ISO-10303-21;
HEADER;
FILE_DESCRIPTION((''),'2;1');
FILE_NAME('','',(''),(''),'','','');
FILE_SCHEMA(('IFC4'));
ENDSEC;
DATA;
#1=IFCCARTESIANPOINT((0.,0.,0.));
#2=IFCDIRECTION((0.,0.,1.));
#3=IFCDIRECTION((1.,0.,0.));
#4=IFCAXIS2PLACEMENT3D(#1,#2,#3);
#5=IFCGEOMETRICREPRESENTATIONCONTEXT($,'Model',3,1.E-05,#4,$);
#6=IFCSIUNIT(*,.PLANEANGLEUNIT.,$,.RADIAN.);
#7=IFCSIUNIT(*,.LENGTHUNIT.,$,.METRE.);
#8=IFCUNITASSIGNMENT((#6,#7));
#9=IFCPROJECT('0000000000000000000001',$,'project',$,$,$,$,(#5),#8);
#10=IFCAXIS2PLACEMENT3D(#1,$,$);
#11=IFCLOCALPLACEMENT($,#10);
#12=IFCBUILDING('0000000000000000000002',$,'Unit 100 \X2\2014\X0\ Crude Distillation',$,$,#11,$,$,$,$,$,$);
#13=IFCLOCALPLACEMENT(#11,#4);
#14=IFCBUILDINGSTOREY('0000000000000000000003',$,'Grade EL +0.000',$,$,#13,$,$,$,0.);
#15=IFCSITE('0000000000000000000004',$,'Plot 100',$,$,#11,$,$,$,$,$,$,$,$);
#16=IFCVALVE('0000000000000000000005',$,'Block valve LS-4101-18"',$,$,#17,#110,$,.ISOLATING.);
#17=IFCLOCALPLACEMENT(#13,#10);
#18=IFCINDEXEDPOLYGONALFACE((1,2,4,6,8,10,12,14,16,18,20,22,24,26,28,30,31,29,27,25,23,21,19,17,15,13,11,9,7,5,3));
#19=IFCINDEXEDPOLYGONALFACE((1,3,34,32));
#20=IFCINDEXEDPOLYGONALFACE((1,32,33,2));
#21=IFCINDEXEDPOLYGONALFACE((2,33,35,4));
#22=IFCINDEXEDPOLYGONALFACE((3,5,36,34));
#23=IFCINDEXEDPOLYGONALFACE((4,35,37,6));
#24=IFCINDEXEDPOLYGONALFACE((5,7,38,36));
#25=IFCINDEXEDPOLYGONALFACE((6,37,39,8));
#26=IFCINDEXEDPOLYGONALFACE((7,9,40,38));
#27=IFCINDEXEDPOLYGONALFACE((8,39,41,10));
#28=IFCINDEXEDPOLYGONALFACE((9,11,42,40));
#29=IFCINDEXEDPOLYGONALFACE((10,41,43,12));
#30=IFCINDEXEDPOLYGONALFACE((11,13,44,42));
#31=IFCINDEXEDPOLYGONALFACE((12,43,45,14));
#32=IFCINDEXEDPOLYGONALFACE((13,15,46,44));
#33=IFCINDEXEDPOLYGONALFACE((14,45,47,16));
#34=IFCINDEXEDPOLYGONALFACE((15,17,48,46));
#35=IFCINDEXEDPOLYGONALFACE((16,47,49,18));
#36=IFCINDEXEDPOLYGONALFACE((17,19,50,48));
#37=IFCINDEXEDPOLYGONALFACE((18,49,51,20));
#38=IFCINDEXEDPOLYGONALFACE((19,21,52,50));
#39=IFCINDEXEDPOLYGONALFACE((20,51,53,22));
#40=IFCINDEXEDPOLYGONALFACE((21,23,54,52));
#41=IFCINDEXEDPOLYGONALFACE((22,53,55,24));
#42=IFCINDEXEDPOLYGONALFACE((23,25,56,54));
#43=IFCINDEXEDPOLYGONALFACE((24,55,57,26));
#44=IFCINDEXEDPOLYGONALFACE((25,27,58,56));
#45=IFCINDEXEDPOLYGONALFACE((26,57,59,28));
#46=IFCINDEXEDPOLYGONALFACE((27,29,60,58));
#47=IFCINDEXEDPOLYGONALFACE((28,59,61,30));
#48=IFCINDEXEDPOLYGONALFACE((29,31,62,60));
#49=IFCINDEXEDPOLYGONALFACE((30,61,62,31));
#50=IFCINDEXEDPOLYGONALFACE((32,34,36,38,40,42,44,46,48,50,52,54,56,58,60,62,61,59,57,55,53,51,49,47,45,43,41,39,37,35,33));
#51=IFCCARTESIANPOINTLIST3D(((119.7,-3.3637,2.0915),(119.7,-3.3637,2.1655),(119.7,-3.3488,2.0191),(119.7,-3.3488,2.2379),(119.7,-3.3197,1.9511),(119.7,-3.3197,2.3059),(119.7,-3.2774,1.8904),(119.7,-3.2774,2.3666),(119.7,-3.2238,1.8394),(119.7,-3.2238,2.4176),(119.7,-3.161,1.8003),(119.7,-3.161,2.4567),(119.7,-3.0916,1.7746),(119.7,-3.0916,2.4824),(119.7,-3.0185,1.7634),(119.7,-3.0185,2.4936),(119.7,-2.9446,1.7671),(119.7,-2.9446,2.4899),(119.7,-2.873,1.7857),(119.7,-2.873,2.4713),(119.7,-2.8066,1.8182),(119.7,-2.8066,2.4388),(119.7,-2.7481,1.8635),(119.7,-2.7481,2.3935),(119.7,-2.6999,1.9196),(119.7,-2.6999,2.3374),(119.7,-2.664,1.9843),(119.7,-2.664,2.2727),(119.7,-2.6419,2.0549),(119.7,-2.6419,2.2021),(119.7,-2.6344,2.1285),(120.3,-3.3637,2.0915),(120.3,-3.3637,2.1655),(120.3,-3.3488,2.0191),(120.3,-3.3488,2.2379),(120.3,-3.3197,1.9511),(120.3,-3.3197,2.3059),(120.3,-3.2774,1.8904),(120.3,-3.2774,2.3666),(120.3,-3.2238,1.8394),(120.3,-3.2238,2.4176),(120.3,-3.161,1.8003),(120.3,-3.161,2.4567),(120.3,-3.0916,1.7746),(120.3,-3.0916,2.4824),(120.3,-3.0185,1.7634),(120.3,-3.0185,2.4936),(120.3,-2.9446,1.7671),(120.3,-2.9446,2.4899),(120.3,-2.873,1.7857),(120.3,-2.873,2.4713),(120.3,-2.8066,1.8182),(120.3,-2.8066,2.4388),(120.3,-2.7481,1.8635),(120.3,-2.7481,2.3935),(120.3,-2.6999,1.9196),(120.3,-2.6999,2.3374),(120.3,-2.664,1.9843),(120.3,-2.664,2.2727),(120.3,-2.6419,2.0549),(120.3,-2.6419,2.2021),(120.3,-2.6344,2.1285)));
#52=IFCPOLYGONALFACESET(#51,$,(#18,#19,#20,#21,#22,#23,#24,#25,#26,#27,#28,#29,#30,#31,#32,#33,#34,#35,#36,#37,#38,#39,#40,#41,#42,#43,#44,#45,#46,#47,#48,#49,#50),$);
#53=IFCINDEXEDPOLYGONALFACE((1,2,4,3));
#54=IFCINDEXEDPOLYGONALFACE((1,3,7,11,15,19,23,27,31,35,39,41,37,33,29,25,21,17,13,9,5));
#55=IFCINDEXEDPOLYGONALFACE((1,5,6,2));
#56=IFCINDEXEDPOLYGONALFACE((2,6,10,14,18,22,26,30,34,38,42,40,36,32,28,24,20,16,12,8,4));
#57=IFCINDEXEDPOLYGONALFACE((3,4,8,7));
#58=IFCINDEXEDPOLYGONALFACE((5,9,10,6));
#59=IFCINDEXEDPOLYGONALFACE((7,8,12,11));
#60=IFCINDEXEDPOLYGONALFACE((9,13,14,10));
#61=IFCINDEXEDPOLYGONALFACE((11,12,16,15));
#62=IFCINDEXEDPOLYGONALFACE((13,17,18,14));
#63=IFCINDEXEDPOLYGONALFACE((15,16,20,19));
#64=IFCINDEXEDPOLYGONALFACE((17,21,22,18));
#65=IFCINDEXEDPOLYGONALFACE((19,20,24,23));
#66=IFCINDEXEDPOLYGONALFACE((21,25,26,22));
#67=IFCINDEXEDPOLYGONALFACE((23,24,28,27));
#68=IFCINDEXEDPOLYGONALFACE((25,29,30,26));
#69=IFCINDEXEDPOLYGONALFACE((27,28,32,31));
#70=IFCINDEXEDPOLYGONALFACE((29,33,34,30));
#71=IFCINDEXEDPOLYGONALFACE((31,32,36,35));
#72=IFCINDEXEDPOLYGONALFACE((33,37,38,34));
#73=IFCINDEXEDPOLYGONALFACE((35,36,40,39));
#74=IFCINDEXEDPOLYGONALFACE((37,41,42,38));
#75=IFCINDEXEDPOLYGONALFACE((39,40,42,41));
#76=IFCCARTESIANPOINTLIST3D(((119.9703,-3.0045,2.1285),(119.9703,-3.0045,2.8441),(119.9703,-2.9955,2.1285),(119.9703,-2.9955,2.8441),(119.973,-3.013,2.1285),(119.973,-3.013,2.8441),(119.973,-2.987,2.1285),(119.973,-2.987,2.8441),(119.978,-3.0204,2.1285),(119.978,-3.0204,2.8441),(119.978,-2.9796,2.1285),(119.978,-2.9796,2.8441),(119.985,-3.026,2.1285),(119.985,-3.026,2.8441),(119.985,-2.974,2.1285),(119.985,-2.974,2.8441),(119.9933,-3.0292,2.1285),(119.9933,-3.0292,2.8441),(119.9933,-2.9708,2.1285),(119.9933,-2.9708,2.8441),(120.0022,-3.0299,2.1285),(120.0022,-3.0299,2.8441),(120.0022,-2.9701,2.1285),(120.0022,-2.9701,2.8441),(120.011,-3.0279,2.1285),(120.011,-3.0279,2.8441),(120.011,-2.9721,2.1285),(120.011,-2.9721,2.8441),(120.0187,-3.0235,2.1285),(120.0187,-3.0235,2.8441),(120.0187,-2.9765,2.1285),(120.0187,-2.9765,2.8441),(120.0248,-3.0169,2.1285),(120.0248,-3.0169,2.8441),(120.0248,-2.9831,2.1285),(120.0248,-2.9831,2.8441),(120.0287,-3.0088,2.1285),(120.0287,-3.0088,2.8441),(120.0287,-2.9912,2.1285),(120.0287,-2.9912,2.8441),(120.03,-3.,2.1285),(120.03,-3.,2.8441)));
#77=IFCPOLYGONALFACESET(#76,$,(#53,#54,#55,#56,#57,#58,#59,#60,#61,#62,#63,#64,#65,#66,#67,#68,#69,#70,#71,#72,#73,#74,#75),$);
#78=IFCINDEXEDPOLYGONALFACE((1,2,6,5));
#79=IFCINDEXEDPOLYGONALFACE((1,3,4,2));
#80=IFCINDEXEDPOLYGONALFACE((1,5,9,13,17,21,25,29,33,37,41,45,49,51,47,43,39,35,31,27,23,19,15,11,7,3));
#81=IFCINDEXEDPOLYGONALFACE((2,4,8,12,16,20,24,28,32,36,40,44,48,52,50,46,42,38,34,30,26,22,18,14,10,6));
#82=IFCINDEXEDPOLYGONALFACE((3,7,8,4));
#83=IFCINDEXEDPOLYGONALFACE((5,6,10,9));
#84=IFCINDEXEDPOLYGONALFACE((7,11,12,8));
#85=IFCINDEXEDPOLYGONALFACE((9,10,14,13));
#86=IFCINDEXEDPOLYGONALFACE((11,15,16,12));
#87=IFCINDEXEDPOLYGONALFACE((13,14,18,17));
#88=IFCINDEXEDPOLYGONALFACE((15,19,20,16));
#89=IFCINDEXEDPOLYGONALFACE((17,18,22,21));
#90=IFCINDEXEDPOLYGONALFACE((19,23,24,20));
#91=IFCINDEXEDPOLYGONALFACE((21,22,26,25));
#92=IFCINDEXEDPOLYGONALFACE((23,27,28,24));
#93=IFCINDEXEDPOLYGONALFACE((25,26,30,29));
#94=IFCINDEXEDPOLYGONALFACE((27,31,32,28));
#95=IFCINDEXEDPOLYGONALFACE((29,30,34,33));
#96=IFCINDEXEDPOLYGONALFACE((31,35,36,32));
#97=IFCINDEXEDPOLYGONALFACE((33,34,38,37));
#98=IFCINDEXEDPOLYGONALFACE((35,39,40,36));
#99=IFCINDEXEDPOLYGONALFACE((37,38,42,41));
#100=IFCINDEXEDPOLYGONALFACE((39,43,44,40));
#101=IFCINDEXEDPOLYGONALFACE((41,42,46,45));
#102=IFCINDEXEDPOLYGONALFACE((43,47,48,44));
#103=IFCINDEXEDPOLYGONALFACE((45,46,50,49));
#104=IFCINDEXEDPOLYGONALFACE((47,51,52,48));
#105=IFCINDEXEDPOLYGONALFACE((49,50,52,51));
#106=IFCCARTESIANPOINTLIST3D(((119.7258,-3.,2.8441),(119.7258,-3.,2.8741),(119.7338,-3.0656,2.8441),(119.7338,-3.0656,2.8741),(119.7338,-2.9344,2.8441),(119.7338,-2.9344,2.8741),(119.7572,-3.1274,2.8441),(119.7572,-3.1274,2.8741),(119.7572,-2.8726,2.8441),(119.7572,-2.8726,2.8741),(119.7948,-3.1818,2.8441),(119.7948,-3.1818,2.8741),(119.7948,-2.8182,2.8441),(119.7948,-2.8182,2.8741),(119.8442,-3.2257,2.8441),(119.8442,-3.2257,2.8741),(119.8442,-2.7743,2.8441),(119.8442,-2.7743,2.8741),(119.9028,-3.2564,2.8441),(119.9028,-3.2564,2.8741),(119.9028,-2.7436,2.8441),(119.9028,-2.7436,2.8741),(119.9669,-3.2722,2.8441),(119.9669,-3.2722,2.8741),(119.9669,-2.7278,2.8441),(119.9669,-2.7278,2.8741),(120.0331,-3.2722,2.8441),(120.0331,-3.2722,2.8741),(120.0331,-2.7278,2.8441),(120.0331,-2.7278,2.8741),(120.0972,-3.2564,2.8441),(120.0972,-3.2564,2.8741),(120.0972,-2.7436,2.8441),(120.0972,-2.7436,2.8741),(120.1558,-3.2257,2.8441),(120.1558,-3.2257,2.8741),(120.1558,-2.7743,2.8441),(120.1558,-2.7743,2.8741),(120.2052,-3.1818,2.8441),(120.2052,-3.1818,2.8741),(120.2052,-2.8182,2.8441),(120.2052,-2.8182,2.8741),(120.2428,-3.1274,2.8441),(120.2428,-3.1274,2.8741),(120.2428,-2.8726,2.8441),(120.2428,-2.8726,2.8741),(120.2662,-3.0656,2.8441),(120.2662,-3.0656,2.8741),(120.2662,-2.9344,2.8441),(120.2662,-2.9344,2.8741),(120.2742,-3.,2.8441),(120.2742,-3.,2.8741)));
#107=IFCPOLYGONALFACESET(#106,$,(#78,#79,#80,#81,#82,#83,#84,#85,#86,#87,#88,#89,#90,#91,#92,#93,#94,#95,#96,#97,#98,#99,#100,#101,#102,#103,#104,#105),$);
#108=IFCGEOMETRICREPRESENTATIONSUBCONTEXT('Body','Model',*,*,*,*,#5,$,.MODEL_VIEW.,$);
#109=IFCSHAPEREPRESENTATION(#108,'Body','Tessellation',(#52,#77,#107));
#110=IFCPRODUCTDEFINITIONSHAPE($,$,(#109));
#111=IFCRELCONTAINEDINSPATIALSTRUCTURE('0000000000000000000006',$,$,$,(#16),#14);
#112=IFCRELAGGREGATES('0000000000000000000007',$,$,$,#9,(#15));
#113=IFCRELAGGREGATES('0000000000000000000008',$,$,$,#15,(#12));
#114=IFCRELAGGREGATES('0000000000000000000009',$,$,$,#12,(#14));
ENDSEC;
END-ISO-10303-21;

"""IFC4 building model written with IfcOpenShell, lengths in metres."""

from ifc_helpers import new_model, si_unit, frame, origin, origin_with_axes, origin_2d, place, context, subcontext, project, spatial, circle, extrude, element, save


model = new_model("IFC4")

# Units and contexts
model_context = context("Model", 3, precision=1e-05, world=origin_with_axes())
body_context = subcontext(model_context, "Body", "Model", "MODEL_VIEW")
ifc_project = project(units=[si_unit("PLANEANGLEUNIT", "RADIAN"), si_unit("LENGTHUNIT", "METRE")], contexts=[model_context])

# Site, building, storey
placement = place(None, origin())
site = spatial("IfcSite", under=ifc_project, at=placement, Name="Plot 100")
building = spatial("IfcBuilding", under=site, at=placement, Name="Unit 100 — Crude Distillation")
storey_placement = place(placement, origin_with_axes())
storey = spatial("IfcBuildingStorey", under=building, at=storey_placement, Name="Grade EL +0.000", Elevation=0.0)

# Valve
valve_1_placement = place(storey_placement, origin_with_axes())
element("IfcValve", 1, at=valve_1_placement, inside=storey, Name="Block valve LS-4101-18\"", PredefinedType="ISOLATING", context=body_context, shape_type="SweptSolid", body=[
    extrude(circle(Radius=0.3656, at=origin_2d()), frame((119.7, -3.0, 2.1285), z_axis=(1.0, 0.0, 0.0), x_axis=(0.0, 1.0, 0.0)), (0.0, 0.0, 1.0), 0.6),
    extrude(circle(Radius=0.03, at=origin_2d()), frame((120.0, -3.0, 2.1285), z_axis=(0.0, 0.0, 1.0), x_axis=(1.0, 0.0, 0.0)), (0.0, 0.0, 1.0), 0.7156),
    extrude(circle(Radius=0.2742, at=origin_2d()), frame((120.0, -3.0, 2.8441), z_axis=(0.0, 0.0, 1.0), x_axis=(1.0, 0.0, 0.0)), (0.0, 0.0, 1.0), 0.03),
])

save(model, "model.ifc")
